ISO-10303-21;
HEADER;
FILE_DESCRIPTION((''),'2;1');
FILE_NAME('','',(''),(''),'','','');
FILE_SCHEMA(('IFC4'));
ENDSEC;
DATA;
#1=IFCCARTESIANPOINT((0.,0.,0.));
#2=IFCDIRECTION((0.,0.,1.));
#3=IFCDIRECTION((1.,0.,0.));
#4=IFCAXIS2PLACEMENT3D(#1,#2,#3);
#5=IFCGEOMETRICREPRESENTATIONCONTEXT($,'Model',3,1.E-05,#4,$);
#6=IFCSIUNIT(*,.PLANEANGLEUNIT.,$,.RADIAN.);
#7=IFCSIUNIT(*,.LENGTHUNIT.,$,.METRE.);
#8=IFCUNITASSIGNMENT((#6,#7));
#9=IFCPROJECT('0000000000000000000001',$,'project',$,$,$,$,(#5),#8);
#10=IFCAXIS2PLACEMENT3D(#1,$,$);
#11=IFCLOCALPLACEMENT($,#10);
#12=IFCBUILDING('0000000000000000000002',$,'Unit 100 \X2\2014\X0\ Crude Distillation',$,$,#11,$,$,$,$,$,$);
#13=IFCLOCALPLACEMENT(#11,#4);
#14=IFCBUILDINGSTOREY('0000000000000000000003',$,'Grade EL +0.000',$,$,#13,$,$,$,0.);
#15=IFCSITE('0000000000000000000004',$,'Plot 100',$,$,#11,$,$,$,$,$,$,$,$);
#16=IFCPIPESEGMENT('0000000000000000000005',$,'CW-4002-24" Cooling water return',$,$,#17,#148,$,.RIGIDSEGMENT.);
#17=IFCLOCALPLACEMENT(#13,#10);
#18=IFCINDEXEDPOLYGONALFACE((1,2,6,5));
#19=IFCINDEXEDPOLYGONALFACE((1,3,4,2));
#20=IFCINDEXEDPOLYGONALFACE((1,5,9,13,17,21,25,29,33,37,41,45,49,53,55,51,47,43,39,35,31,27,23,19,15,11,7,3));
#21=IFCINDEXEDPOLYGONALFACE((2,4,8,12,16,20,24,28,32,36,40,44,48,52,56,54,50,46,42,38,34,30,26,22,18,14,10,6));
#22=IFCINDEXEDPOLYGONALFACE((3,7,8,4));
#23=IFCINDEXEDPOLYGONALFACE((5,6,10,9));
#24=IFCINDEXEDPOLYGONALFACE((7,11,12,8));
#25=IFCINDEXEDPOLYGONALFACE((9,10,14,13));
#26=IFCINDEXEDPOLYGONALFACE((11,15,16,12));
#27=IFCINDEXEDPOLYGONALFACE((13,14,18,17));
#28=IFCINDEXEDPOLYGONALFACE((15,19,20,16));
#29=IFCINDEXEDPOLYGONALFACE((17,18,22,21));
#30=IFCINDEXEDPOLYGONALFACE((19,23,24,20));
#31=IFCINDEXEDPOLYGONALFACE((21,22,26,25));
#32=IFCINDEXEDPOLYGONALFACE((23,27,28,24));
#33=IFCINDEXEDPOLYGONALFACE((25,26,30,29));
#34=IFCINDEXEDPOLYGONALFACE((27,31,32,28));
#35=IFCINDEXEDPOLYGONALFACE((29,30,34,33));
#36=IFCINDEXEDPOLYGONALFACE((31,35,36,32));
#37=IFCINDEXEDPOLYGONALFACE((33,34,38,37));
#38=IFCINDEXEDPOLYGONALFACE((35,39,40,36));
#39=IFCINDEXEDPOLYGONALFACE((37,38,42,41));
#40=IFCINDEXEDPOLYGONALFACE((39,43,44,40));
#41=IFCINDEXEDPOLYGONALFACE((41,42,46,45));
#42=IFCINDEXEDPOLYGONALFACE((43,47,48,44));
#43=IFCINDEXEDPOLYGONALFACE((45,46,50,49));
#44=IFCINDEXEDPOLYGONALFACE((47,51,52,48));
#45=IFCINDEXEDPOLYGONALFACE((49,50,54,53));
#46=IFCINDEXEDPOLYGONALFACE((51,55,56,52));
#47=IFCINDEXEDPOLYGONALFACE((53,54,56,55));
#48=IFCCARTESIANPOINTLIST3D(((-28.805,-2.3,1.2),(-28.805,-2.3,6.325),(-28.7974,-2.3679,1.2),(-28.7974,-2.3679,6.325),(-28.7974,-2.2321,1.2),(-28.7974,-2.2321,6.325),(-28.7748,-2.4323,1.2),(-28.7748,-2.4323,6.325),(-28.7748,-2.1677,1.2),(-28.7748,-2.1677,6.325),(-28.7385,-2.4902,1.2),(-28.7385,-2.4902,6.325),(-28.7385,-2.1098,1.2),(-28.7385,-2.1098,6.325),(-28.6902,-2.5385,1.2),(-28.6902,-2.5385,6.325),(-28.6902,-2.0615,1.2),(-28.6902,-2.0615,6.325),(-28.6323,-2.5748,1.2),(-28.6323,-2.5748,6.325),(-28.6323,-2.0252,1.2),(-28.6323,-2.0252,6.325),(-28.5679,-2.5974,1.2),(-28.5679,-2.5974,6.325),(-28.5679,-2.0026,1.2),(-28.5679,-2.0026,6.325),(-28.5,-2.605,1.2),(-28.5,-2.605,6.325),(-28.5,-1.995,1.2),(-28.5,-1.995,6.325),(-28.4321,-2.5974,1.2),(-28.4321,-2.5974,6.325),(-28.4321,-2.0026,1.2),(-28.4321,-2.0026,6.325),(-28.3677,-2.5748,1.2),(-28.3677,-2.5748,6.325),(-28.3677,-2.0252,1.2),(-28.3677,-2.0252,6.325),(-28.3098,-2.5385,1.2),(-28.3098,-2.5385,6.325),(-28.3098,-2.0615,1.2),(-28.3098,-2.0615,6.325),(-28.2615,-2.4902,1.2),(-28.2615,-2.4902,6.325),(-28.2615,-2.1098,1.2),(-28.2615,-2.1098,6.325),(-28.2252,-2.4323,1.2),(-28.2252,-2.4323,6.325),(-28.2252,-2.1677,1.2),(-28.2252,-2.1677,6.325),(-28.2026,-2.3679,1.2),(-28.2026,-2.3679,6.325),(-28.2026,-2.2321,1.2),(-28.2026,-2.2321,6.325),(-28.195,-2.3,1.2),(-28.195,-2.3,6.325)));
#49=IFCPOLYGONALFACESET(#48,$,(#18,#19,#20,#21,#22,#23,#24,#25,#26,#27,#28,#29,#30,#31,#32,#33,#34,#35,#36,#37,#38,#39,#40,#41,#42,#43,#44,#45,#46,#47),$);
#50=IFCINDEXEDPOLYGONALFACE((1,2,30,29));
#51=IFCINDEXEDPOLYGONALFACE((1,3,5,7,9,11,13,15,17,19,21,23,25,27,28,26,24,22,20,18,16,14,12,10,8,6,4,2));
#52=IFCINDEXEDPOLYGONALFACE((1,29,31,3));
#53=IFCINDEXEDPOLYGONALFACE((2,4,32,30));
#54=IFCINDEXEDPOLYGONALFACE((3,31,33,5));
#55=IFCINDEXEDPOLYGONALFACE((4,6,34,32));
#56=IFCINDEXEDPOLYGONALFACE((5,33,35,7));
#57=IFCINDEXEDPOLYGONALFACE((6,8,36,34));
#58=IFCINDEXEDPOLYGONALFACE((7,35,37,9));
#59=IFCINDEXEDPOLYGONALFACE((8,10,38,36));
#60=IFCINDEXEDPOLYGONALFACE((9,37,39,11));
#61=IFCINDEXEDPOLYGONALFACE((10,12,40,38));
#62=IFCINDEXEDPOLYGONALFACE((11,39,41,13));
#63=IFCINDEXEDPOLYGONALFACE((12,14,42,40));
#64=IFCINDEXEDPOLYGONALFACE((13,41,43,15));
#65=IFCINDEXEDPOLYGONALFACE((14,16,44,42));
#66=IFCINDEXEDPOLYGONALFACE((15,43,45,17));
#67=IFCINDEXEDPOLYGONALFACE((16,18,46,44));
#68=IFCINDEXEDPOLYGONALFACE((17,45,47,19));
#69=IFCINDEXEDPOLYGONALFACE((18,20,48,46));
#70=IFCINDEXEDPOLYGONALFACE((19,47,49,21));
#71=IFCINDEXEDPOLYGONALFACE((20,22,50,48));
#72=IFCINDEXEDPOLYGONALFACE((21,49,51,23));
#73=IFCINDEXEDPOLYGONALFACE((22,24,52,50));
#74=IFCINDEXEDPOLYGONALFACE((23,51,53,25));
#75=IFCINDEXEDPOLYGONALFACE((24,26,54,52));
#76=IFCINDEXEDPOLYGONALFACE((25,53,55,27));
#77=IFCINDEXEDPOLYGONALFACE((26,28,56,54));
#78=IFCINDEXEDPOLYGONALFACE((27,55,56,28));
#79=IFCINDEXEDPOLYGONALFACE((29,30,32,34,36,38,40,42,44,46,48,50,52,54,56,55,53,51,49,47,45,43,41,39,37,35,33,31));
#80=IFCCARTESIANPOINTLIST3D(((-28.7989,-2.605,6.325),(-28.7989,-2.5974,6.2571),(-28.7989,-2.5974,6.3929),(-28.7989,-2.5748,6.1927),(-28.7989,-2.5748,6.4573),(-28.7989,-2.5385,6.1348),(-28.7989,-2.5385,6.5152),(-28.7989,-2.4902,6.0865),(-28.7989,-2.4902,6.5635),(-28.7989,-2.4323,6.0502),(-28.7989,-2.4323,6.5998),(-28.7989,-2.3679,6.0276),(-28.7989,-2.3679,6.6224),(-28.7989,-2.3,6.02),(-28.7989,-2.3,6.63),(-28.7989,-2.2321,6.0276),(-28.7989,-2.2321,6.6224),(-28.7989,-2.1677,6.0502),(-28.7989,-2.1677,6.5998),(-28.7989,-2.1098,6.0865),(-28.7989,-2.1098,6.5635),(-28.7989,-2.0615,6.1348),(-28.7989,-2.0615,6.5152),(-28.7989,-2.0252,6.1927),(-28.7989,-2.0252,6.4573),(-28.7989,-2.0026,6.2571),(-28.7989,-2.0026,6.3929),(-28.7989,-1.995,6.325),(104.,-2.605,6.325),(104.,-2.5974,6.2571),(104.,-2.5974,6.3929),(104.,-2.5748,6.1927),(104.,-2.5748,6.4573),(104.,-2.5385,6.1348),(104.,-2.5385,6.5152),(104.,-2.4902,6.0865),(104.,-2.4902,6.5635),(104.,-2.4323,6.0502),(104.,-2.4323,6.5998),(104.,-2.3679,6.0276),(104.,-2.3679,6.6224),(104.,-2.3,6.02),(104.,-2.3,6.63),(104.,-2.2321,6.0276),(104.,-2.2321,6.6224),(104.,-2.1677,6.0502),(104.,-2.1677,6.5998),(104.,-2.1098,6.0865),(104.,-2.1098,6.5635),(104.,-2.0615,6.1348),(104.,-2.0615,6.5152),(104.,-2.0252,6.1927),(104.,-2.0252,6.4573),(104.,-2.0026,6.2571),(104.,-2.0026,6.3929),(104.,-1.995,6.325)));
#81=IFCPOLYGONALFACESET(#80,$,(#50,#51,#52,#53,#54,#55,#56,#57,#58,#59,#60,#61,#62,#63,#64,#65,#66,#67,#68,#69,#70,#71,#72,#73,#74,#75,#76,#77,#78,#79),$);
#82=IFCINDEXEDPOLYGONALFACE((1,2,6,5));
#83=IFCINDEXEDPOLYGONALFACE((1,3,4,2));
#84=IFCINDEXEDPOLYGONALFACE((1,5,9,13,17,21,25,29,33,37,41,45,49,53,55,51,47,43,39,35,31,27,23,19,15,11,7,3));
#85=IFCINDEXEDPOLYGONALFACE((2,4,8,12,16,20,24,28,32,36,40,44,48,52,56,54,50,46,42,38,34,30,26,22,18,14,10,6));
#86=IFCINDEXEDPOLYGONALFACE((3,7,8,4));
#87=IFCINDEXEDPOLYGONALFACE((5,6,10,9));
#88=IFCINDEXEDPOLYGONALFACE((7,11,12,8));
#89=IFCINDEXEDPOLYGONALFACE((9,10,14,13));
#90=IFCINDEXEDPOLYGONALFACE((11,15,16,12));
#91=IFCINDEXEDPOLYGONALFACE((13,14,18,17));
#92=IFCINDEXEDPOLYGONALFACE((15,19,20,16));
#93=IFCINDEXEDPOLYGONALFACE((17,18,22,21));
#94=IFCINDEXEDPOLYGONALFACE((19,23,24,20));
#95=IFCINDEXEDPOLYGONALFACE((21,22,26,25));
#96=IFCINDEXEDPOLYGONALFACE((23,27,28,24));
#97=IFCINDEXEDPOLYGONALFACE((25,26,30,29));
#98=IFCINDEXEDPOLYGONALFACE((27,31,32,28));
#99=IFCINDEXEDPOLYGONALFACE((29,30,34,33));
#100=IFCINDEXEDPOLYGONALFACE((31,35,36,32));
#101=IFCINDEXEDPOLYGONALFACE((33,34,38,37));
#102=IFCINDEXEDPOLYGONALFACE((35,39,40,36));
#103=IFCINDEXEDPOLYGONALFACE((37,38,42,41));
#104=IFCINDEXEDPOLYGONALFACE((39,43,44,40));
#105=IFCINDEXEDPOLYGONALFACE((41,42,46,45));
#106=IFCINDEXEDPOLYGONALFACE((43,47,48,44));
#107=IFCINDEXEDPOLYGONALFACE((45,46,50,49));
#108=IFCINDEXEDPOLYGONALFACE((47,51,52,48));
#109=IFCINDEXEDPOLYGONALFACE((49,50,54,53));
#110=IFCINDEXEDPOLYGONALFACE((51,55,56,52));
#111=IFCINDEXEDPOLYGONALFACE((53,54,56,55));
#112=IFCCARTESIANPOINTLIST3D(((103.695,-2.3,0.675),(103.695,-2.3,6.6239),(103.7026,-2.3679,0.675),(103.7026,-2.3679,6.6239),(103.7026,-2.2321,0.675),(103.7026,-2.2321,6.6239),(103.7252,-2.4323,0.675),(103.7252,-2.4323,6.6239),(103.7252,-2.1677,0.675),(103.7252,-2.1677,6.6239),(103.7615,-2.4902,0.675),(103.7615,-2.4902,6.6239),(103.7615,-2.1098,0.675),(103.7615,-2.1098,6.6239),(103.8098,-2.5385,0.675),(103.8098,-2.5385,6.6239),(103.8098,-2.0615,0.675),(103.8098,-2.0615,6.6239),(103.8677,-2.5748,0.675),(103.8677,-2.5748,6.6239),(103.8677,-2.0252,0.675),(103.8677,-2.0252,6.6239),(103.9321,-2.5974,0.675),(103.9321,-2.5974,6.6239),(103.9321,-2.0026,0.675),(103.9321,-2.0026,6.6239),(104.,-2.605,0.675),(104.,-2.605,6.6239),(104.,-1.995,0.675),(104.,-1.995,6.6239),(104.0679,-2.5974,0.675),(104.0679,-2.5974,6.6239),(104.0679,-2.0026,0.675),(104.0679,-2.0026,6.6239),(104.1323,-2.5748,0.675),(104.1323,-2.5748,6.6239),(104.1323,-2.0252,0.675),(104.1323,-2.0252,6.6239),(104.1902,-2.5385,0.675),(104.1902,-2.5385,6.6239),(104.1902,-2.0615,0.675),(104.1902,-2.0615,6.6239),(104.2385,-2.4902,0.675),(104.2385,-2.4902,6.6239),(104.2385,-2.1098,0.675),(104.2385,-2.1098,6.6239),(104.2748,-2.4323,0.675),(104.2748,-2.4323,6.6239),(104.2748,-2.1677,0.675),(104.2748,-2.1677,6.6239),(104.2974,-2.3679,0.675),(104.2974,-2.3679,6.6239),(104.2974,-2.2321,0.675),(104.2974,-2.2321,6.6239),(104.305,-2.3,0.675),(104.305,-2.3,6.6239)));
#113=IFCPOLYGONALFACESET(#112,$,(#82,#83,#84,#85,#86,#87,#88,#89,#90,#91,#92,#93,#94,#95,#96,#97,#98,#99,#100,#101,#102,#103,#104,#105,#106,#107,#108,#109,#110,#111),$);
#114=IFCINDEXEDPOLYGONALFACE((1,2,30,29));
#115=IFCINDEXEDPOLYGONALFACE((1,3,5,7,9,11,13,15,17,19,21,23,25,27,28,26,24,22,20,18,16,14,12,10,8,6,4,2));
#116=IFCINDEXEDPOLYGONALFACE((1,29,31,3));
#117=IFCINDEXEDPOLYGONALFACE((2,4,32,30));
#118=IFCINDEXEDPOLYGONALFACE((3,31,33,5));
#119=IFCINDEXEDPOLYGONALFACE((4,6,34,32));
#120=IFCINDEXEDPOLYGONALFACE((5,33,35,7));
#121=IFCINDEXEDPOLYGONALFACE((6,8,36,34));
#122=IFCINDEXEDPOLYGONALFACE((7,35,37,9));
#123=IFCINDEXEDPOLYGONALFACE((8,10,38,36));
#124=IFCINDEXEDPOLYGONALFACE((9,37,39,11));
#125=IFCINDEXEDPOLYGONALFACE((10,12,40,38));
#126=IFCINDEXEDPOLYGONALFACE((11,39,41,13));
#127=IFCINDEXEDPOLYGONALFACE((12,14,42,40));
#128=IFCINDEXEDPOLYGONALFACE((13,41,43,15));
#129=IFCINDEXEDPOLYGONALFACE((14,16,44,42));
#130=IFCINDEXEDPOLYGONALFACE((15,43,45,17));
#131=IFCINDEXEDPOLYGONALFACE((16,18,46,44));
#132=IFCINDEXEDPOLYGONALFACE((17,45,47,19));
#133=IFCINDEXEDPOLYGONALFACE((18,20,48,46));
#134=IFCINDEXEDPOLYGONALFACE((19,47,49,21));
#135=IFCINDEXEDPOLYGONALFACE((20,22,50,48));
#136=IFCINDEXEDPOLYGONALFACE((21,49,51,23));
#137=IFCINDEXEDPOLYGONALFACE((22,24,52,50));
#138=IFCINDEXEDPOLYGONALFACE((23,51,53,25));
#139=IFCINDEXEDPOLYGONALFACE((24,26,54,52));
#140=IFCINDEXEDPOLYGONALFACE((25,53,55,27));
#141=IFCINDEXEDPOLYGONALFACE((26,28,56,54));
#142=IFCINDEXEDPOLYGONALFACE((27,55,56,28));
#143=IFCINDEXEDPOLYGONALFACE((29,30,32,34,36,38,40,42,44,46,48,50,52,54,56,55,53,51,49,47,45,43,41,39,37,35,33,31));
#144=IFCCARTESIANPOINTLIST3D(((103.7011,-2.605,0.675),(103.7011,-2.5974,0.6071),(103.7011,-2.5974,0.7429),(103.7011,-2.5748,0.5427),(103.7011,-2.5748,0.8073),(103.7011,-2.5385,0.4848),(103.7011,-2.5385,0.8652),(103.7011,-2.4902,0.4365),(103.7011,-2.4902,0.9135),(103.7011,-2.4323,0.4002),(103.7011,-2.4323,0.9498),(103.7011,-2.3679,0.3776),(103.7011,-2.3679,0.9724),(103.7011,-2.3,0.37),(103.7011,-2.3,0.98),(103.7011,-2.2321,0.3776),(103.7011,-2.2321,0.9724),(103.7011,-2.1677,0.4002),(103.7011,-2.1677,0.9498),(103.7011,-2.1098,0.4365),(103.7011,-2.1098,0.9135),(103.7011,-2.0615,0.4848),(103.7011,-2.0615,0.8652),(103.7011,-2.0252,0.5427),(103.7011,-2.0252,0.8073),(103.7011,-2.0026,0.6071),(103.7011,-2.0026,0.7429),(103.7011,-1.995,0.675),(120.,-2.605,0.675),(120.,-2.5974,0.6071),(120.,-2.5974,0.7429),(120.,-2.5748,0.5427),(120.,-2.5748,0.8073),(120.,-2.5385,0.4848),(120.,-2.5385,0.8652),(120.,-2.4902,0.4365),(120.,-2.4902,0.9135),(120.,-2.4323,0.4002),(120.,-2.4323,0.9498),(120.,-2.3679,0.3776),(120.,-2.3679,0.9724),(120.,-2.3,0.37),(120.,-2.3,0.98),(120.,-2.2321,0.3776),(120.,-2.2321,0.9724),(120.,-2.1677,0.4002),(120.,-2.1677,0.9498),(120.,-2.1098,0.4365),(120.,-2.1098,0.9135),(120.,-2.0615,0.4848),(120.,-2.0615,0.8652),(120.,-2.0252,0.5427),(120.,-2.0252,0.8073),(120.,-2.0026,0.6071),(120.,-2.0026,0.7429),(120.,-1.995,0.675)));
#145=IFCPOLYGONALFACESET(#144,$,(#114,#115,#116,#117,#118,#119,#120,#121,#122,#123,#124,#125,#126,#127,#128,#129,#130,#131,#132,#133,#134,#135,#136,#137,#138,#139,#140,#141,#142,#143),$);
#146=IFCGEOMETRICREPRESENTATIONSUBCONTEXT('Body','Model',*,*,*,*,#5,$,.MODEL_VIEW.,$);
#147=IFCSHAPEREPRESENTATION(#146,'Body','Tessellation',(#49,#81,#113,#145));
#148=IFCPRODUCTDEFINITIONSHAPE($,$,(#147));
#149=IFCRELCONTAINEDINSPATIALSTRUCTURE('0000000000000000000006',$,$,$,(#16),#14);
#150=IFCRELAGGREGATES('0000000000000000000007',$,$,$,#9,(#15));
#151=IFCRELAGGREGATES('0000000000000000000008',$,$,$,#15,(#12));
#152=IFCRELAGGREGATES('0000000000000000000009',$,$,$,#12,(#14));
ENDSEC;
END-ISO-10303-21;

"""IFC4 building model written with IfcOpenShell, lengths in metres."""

from ifc_helpers import new_model, si_unit, frame, origin, origin_with_axes, origin_2d, place, context, subcontext, project, spatial, circle, extrude, element, save


model = new_model("IFC4")

# Units and contexts
model_context = context("Model", 3, precision=1e-05, world=origin_with_axes())
body_context = subcontext(model_context, "Body", "Model", "MODEL_VIEW")
ifc_project = project(units=[si_unit("PLANEANGLEUNIT", "RADIAN"), si_unit("LENGTHUNIT", "METRE")], contexts=[model_context])

# Site, building, storey
placement = place(None, origin())
site = spatial("IfcSite", under=ifc_project, at=placement, Name="Plot 100")
building = spatial("IfcBuilding", under=site, at=placement, Name="Unit 100 — Crude Distillation")
storey_placement = place(placement, origin_with_axes())
storey = spatial("IfcBuildingStorey", under=building, at=storey_placement, Name="Grade EL +0.000", Elevation=0.0)

# Pipe segment
pipe_segment_1_placement = place(storey_placement, origin_with_axes())
element("IfcPipeSegment", 1, at=pipe_segment_1_placement, inside=storey, Name="CW-4002-24\" Cooling water return", PredefinedType="RIGIDSEGMENT", context=body_context, shape_type="SweptSolid", body=[
    extrude(circle(Radius=0.305, at=origin_2d()), frame((-28.5, -2.3, 1.2), z_axis=(0.0, 0.0, 1.0), x_axis=(1.0, 0.0, 0.0)), (0.0, 0.0, 1.0), 5.125),
    extrude(circle(Radius=0.305, at=origin_2d()), frame((-28.7989, -2.3, 6.325), z_axis=(1.0, 0.0, 0.0), x_axis=(0.0, 1.0, 0.0)), (0.0, 0.0, 1.0), 132.7989),
    extrude(circle(Radius=0.305, at=origin_2d()), frame((104.0, -2.3, 6.6239), z_axis=(0.0, 0.0, -1.0), x_axis=(1.0, 0.0, 0.0)), (0.0, 0.0, 1.0), 5.9489),
    extrude(circle(Radius=0.305, at=origin_2d()), frame((103.7011, -2.3, 0.675), z_axis=(1.0, 0.0, 0.0), x_axis=(0.0, 1.0, 0.0)), (0.0, 0.0, 1.0), 16.2989),
])

save(model, "model.ifc")
